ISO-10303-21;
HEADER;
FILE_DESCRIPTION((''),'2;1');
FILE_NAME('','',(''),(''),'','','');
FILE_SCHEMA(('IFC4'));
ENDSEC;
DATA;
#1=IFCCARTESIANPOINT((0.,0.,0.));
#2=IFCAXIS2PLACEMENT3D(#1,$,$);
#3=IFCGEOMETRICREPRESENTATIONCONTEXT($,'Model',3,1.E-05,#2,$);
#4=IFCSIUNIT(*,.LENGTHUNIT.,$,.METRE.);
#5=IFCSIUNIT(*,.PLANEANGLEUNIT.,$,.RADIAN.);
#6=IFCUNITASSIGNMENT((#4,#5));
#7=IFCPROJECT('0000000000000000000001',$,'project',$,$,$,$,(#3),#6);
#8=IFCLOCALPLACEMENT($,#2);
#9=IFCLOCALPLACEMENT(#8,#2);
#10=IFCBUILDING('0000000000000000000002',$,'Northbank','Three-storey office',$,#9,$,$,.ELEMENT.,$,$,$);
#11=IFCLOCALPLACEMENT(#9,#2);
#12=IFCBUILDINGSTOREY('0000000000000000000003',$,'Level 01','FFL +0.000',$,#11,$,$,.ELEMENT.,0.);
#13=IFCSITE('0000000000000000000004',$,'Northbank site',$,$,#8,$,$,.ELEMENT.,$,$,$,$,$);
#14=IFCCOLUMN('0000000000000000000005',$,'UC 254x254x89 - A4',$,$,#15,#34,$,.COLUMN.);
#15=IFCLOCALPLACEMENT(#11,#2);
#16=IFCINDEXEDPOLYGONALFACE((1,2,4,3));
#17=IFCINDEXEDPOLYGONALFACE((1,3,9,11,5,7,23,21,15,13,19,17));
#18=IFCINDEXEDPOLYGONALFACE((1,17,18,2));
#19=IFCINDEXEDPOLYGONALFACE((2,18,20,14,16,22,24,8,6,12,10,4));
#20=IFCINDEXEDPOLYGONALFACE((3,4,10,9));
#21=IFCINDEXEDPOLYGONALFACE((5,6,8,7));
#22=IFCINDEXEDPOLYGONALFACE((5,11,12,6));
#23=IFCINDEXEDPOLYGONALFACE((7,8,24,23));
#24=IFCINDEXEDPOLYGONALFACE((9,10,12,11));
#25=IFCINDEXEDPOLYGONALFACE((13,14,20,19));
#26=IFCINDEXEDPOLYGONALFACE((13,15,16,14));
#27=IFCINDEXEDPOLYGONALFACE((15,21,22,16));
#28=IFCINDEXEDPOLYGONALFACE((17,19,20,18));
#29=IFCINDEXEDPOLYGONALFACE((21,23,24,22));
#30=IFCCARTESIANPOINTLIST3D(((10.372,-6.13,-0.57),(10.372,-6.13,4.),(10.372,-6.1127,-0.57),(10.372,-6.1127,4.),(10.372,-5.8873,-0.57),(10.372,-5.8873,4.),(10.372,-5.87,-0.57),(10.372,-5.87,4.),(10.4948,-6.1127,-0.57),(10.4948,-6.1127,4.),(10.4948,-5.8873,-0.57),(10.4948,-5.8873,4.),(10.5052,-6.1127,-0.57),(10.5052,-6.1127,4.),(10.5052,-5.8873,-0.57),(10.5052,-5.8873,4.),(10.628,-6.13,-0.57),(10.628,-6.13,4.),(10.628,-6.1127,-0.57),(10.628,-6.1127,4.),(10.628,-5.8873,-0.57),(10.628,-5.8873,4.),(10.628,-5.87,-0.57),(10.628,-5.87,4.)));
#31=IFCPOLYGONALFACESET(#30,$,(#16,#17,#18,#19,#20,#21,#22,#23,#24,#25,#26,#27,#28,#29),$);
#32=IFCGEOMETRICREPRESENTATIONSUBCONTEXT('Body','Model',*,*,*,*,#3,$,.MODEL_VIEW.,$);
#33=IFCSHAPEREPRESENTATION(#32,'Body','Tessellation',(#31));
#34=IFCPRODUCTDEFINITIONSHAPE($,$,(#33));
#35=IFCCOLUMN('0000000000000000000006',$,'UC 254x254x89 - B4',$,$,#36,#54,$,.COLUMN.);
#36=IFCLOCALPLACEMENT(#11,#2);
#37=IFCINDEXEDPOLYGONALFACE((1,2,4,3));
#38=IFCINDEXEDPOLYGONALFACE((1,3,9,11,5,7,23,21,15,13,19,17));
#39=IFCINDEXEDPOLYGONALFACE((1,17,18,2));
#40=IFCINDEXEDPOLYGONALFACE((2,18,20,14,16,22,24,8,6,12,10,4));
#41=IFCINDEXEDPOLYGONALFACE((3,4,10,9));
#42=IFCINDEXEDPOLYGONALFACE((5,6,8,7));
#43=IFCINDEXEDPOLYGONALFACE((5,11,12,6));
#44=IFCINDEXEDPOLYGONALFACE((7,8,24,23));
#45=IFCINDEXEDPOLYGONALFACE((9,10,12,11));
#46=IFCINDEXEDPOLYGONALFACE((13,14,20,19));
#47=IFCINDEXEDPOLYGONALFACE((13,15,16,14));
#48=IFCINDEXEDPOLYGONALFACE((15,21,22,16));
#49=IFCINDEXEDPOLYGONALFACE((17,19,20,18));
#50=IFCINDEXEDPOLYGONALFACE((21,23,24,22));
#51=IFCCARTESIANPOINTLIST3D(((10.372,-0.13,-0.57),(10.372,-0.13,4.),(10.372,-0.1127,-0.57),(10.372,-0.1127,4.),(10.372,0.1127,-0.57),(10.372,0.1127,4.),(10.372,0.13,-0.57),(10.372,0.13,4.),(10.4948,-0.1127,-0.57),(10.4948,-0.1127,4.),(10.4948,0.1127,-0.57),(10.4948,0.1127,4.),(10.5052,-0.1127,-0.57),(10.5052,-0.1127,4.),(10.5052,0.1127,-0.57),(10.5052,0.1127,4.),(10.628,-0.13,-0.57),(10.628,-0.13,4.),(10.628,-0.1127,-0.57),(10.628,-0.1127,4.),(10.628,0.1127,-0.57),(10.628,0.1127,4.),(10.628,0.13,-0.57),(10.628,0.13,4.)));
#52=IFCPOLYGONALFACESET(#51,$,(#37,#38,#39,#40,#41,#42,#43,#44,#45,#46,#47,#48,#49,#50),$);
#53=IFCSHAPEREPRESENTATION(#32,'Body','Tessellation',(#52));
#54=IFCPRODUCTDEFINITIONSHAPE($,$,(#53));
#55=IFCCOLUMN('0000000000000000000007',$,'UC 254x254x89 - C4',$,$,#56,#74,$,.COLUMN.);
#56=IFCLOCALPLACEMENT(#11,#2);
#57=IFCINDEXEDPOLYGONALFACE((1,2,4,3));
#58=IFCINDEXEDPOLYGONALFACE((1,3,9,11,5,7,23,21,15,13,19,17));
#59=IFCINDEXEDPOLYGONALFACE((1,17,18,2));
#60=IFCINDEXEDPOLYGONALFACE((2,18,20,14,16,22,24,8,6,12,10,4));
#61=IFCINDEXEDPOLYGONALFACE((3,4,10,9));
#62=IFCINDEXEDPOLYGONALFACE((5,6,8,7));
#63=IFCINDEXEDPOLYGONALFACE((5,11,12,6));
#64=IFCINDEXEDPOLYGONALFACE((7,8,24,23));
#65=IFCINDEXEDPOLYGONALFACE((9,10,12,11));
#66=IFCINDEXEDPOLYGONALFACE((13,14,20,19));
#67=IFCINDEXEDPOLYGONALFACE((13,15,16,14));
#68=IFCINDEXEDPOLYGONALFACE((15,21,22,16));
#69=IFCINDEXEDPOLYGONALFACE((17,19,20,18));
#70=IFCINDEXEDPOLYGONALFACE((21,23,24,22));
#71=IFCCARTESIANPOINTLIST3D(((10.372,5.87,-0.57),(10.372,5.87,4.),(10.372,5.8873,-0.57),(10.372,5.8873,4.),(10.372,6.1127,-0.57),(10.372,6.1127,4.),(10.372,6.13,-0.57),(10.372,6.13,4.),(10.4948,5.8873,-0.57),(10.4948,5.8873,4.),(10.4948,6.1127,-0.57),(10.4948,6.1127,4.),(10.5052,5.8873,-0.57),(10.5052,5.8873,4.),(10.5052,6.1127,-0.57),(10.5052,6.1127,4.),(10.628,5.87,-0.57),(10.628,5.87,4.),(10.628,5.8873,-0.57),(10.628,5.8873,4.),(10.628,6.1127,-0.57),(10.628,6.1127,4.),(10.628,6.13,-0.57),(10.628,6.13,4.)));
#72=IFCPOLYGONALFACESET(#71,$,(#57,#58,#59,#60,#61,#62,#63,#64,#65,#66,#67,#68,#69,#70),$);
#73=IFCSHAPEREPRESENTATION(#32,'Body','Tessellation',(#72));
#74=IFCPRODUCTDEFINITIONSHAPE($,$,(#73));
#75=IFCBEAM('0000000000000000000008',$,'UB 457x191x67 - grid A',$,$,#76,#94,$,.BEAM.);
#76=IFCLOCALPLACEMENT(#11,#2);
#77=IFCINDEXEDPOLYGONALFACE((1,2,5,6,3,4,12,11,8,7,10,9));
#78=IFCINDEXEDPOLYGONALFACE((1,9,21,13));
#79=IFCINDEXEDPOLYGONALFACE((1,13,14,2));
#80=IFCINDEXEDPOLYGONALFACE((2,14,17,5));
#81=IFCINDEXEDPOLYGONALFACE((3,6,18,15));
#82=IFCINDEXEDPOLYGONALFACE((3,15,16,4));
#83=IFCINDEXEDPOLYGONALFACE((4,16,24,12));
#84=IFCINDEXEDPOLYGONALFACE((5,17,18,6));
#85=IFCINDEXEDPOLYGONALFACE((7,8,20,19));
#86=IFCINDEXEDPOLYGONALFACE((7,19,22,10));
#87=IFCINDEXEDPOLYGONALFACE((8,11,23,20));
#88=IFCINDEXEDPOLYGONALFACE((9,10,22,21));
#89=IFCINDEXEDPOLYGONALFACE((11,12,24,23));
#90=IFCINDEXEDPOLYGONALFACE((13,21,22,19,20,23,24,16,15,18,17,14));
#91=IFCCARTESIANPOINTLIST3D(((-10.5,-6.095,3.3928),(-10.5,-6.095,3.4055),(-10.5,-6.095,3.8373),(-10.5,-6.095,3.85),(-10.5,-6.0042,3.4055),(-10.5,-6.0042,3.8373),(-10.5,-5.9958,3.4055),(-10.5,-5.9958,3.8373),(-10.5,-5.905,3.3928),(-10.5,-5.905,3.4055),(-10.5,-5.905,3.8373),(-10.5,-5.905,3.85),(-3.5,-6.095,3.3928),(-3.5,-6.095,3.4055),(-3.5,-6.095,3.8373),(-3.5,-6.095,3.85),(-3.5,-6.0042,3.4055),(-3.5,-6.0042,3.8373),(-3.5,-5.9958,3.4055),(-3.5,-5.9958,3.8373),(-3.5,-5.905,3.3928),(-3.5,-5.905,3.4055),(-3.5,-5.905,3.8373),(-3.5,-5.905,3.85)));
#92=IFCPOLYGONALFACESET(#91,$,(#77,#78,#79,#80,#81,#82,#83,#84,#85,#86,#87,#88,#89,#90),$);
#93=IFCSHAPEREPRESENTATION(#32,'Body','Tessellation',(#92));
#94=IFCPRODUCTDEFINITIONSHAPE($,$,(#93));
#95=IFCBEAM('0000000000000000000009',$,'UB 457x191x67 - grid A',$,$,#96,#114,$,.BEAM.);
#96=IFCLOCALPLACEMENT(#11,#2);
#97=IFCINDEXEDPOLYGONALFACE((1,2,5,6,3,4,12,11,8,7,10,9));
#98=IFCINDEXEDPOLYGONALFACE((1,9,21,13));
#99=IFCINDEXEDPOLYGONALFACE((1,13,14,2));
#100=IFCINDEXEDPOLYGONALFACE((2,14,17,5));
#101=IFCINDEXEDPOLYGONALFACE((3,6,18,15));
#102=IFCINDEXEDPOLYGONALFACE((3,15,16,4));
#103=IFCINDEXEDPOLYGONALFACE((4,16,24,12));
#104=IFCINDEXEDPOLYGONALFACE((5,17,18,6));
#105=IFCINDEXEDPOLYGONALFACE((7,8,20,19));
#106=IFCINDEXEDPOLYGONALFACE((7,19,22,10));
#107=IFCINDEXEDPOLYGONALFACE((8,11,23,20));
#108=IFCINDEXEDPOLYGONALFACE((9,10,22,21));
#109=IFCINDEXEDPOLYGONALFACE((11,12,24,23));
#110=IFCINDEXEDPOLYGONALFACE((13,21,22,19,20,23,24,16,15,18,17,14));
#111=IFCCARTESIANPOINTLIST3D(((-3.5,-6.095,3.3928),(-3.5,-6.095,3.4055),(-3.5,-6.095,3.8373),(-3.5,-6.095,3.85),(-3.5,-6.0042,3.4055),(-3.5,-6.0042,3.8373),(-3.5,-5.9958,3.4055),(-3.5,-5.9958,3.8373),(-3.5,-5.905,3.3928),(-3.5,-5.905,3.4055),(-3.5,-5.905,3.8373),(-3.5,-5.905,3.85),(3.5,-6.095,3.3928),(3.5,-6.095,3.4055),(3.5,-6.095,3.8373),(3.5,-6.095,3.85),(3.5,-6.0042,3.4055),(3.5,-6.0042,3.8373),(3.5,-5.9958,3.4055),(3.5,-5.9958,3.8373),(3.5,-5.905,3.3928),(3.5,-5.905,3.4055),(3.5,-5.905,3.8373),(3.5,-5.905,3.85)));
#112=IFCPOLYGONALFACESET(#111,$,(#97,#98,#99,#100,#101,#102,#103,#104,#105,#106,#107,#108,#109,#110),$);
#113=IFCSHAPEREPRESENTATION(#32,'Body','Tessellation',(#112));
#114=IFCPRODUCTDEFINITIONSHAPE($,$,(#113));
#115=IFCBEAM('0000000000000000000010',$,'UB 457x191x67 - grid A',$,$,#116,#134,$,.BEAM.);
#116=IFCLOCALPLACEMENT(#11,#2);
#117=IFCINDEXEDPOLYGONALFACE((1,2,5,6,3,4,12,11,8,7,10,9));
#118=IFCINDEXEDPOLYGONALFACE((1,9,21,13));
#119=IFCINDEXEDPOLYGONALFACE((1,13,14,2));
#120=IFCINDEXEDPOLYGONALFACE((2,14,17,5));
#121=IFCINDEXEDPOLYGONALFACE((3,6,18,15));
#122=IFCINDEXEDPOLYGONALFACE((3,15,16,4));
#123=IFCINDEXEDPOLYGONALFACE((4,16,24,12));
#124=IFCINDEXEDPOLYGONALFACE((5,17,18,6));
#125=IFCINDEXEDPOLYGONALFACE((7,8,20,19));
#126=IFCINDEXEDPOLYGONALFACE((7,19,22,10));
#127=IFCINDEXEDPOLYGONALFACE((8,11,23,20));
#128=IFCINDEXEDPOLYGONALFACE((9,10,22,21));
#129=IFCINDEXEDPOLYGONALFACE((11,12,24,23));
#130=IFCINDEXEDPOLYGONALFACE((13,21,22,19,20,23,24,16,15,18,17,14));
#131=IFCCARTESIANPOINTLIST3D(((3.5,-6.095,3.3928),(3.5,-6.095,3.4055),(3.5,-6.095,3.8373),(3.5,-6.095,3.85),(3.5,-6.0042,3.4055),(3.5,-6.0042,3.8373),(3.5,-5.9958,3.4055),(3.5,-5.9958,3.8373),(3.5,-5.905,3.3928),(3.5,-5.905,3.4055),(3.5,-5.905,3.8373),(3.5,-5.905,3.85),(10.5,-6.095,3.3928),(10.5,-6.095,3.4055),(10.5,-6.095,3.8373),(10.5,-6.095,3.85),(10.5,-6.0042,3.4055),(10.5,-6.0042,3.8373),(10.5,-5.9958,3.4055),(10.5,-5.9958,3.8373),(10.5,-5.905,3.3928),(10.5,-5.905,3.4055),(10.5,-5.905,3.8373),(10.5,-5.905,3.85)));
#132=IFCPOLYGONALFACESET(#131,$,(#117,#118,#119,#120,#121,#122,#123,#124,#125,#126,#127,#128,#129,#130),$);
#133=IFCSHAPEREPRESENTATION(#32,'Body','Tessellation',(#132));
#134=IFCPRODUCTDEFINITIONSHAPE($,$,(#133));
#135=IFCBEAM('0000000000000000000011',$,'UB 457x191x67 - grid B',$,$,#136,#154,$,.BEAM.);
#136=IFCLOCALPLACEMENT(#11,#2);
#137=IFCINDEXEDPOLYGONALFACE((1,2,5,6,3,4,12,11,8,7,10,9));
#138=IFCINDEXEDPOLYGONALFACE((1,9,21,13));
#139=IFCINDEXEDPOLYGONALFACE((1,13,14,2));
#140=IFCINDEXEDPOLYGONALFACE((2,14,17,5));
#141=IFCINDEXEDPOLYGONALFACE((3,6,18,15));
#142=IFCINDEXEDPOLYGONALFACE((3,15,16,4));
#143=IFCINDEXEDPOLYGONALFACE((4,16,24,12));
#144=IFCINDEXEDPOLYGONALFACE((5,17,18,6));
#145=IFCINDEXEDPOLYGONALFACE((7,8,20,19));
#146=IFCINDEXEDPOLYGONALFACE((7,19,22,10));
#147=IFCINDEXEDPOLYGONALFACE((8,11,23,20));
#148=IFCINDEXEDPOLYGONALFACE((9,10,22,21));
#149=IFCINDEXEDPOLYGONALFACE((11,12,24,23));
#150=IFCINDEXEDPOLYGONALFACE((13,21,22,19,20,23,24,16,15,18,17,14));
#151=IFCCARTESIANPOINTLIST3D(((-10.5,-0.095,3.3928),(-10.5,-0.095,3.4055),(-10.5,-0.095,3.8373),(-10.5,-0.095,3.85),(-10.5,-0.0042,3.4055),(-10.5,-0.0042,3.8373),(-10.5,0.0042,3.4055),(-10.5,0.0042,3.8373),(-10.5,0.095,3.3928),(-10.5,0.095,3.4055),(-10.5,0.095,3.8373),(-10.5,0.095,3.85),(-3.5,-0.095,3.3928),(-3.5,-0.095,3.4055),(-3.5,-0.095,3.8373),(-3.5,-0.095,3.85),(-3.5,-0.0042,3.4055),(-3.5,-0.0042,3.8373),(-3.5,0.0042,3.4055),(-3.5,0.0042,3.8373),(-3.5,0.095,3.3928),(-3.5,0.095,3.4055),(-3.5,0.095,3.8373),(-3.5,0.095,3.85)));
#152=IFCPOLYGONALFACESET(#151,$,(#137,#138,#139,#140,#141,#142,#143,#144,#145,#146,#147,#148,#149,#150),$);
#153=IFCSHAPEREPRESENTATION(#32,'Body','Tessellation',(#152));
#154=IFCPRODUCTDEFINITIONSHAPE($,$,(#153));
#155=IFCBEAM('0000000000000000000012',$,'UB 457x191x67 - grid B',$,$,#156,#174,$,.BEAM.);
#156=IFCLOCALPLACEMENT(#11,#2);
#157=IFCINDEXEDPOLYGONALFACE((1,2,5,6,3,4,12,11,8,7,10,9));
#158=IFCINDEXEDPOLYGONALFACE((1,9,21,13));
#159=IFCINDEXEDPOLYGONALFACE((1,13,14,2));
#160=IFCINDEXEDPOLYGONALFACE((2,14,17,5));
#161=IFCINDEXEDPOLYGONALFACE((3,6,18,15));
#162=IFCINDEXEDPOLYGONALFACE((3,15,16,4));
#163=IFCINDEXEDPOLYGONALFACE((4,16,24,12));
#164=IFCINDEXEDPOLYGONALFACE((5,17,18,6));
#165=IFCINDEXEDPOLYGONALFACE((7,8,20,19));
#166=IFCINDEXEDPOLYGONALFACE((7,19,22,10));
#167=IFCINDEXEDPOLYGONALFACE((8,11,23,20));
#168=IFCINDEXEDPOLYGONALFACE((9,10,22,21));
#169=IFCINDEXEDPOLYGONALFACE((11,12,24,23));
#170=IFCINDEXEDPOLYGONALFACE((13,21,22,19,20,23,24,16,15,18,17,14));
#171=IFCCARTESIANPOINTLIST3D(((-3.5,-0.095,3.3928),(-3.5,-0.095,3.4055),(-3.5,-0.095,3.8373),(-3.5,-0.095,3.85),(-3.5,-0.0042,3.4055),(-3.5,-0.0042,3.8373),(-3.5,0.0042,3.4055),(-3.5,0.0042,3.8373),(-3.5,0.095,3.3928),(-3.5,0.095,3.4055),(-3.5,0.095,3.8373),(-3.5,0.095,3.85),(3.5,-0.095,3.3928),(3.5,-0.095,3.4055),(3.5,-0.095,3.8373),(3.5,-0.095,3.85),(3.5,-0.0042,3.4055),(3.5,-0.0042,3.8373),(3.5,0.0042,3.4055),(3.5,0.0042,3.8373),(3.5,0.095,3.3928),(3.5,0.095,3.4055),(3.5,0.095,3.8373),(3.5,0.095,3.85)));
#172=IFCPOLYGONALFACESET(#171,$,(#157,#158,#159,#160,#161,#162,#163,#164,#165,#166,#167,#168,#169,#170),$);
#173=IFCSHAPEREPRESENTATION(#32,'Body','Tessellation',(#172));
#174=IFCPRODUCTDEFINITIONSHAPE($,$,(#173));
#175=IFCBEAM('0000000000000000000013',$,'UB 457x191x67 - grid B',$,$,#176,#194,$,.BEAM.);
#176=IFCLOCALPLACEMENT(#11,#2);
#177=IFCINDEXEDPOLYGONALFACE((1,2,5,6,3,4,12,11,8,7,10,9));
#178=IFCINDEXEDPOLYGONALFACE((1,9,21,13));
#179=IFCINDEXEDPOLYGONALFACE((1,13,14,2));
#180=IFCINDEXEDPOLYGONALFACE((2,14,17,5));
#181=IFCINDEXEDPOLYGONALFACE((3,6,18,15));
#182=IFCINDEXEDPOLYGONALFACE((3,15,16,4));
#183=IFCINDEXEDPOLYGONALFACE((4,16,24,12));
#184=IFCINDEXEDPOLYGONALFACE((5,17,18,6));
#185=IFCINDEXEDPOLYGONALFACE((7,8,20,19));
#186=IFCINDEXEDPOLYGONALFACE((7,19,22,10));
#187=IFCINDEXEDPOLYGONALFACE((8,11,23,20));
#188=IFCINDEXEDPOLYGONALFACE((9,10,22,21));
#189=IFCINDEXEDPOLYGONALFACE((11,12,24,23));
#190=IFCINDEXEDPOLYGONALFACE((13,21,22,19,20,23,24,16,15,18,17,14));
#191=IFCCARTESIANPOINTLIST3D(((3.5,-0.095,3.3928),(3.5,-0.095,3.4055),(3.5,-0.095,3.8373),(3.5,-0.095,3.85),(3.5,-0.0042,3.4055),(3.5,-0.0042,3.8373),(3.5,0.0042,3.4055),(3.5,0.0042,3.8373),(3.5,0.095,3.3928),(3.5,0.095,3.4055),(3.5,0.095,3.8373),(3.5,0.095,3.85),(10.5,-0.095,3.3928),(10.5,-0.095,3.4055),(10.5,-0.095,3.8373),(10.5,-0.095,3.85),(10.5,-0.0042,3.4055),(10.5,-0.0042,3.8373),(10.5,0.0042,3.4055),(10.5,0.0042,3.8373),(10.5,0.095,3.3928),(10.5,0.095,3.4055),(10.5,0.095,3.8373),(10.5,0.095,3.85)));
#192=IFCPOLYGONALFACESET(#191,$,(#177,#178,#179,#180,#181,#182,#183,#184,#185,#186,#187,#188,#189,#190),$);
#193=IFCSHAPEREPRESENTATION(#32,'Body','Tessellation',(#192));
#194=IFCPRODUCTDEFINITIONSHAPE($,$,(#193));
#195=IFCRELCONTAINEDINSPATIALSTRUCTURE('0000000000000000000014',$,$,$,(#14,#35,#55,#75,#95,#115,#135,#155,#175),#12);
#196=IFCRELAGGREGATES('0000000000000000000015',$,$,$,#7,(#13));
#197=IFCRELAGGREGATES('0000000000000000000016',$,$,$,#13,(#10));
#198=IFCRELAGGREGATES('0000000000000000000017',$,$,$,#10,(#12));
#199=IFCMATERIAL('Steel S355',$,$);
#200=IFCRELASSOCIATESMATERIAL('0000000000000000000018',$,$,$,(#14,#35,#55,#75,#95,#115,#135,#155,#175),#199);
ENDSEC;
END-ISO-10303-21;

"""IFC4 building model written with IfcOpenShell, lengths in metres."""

from ifc_helpers import new_model, si_unit, frame, origin, place, context, subcontext, project, spatial, i_section, extrude, material, element, save


model = new_model("IFC4")

# Units and contexts
model_context = context("Model", 3, precision=1e-05, world=origin())
body_context = subcontext(model_context, "Body", "Model", "MODEL_VIEW")
ifc_project = project(units=[si_unit("LENGTHUNIT", "METRE"), si_unit("PLANEANGLEUNIT", "RADIAN")], contexts=[model_context])

# Site, building, storey
site_placement = place(None, origin())
site = spatial("IfcSite", under=ifc_project, at=site_placement, Name="Northbank site", CompositionType="ELEMENT")
building_placement = place(site_placement, origin())
building = spatial("IfcBuilding", under=site, at=building_placement, Name="Northbank", Description="Three-storey office", CompositionType="ELEMENT")
storey_placement = place(building_placement, origin())
storey = spatial("IfcBuildingStorey", under=building, at=storey_placement, Name="Level 01", Description="FFL +0.000", CompositionType="ELEMENT", Elevation=0.0)

# Columns
ifc_material_1 = material(Name="Steel S355")
column_1_placement = place(storey_placement, origin())
element("IfcColumn", 1, at=column_1_placement, inside=storey, material=ifc_material_1, Name="UC 254x254x89 - A4", PredefinedType="COLUMN", context=body_context, shape_type="SweptSolid", body=[
    extrude(i_section(OverallWidth=0.256, OverallDepth=0.26, WebThickness=0.0103, FlangeThickness=0.0173), frame((10.5, -6.0, -0.57), z_axis=(0.0, 0.0, 1.0), x_axis=(1.0, 0.0, 0.0)), (0.0, 0.0, 1.0), 4.57),
])
column_2_placement = place(storey_placement, origin())
element("IfcColumn", 2, at=column_2_placement, inside=storey, material=ifc_material_1, Name="UC 254x254x89 - B4", PredefinedType="COLUMN", context=body_context, shape_type="SweptSolid", body=[
    extrude(i_section(OverallWidth=0.256, OverallDepth=0.26, WebThickness=0.0103, FlangeThickness=0.0173), frame((10.5, 0.0, -0.57), z_axis=(0.0, 0.0, 1.0), x_axis=(1.0, 0.0, 0.0)), (0.0, 0.0, 1.0), 4.57),
])
column_3_placement = place(storey_placement, origin())
element("IfcColumn", 3, at=column_3_placement, inside=storey, material=ifc_material_1, Name="UC 254x254x89 - C4", PredefinedType="COLUMN", context=body_context, shape_type="SweptSolid", body=[
    extrude(i_section(OverallWidth=0.256, OverallDepth=0.26, WebThickness=0.0103, FlangeThickness=0.0173), frame((10.5, 6.0, -0.57), z_axis=(0.0, 0.0, 1.0), x_axis=(1.0, 0.0, 0.0)), (0.0, 0.0, 1.0), 4.57),
])

# Beams
beam_1_placement = place(storey_placement, origin())
element("IfcBeam", 4, at=beam_1_placement, inside=storey, material=ifc_material_1, Name="UB 457x191x67 - grid A", PredefinedType="BEAM", context=body_context, shape_type="SweptSolid", body=[
    extrude(i_section(OverallWidth=0.1899, OverallDepth=0.4572, WebThickness=0.0085, FlangeThickness=0.0127), frame((-10.5, -6.0, 3.6214), z_axis=(1.0, 0.0, 0.0), x_axis=(0.0, 1.0, 0.0)), (0.0, 0.0, 1.0), 7.0),
])
beam_2_placement = place(storey_placement, origin())
element("IfcBeam", 5, at=beam_2_placement, inside=storey, material=ifc_material_1, Name="UB 457x191x67 - grid A", PredefinedType="BEAM", context=body_context, shape_type="SweptSolid", body=[
    extrude(i_section(OverallWidth=0.1899, OverallDepth=0.4572, WebThickness=0.0085, FlangeThickness=0.0127), frame((-3.5, -6.0, 3.6214), z_axis=(1.0, 0.0, 0.0), x_axis=(0.0, 1.0, 0.0)), (0.0, 0.0, 1.0), 7.0),
])
beam_3_placement = place(storey_placement, origin())
element("IfcBeam", 6, at=beam_3_placement, inside=storey, material=ifc_material_1, Name="UB 457x191x67 - grid A", PredefinedType="BEAM", context=body_context, shape_type="SweptSolid", body=[
    extrude(i_section(OverallWidth=0.1899, OverallDepth=0.4572, WebThickness=0.0085, FlangeThickness=0.0127), frame((3.5, -6.0, 3.6214), z_axis=(1.0, 0.0, 0.0), x_axis=(0.0, 1.0, 0.0)), (0.0, 0.0, 1.0), 7.0),
])
beam_4_placement = place(storey_placement, origin())
element("IfcBeam", 7, at=beam_4_placement, inside=storey, material=ifc_material_1, Name="UB 457x191x67 - grid B", PredefinedType="BEAM", context=body_context, shape_type="SweptSolid", body=[
    extrude(i_section(OverallWidth=0.1899, OverallDepth=0.4572, WebThickness=0.0085, FlangeThickness=0.0127), frame((-10.5, 0.0, 3.6214), z_axis=(1.0, 0.0, 0.0), x_axis=(0.0, 1.0, 0.0)), (0.0, 0.0, 1.0), 7.0),
])
beam_5_placement = place(storey_placement, origin())
element("IfcBeam", 8, at=beam_5_placement, inside=storey, material=ifc_material_1, Name="UB 457x191x67 - grid B", PredefinedType="BEAM", context=body_context, shape_type="SweptSolid", body=[
    extrude(i_section(OverallWidth=0.1899, OverallDepth=0.4572, WebThickness=0.0085, FlangeThickness=0.0127), frame((-3.5, 0.0, 3.6214), z_axis=(1.0, 0.0, 0.0), x_axis=(0.0, 1.0, 0.0)), (0.0, 0.0, 1.0), 7.0),
])
beam_6_placement = place(storey_placement, origin())
element("IfcBeam", 9, at=beam_6_placement, inside=storey, material=ifc_material_1, Name="UB 457x191x67 - grid B", PredefinedType="BEAM", context=body_context, shape_type="SweptSolid", body=[
    extrude(i_section(OverallWidth=0.1899, OverallDepth=0.4572, WebThickness=0.0085, FlangeThickness=0.0127), frame((3.5, 0.0, 3.6214), z_axis=(1.0, 0.0, 0.0), x_axis=(0.0, 1.0, 0.0)), (0.0, 0.0, 1.0), 7.0),
])

save(model, "model.ifc")
